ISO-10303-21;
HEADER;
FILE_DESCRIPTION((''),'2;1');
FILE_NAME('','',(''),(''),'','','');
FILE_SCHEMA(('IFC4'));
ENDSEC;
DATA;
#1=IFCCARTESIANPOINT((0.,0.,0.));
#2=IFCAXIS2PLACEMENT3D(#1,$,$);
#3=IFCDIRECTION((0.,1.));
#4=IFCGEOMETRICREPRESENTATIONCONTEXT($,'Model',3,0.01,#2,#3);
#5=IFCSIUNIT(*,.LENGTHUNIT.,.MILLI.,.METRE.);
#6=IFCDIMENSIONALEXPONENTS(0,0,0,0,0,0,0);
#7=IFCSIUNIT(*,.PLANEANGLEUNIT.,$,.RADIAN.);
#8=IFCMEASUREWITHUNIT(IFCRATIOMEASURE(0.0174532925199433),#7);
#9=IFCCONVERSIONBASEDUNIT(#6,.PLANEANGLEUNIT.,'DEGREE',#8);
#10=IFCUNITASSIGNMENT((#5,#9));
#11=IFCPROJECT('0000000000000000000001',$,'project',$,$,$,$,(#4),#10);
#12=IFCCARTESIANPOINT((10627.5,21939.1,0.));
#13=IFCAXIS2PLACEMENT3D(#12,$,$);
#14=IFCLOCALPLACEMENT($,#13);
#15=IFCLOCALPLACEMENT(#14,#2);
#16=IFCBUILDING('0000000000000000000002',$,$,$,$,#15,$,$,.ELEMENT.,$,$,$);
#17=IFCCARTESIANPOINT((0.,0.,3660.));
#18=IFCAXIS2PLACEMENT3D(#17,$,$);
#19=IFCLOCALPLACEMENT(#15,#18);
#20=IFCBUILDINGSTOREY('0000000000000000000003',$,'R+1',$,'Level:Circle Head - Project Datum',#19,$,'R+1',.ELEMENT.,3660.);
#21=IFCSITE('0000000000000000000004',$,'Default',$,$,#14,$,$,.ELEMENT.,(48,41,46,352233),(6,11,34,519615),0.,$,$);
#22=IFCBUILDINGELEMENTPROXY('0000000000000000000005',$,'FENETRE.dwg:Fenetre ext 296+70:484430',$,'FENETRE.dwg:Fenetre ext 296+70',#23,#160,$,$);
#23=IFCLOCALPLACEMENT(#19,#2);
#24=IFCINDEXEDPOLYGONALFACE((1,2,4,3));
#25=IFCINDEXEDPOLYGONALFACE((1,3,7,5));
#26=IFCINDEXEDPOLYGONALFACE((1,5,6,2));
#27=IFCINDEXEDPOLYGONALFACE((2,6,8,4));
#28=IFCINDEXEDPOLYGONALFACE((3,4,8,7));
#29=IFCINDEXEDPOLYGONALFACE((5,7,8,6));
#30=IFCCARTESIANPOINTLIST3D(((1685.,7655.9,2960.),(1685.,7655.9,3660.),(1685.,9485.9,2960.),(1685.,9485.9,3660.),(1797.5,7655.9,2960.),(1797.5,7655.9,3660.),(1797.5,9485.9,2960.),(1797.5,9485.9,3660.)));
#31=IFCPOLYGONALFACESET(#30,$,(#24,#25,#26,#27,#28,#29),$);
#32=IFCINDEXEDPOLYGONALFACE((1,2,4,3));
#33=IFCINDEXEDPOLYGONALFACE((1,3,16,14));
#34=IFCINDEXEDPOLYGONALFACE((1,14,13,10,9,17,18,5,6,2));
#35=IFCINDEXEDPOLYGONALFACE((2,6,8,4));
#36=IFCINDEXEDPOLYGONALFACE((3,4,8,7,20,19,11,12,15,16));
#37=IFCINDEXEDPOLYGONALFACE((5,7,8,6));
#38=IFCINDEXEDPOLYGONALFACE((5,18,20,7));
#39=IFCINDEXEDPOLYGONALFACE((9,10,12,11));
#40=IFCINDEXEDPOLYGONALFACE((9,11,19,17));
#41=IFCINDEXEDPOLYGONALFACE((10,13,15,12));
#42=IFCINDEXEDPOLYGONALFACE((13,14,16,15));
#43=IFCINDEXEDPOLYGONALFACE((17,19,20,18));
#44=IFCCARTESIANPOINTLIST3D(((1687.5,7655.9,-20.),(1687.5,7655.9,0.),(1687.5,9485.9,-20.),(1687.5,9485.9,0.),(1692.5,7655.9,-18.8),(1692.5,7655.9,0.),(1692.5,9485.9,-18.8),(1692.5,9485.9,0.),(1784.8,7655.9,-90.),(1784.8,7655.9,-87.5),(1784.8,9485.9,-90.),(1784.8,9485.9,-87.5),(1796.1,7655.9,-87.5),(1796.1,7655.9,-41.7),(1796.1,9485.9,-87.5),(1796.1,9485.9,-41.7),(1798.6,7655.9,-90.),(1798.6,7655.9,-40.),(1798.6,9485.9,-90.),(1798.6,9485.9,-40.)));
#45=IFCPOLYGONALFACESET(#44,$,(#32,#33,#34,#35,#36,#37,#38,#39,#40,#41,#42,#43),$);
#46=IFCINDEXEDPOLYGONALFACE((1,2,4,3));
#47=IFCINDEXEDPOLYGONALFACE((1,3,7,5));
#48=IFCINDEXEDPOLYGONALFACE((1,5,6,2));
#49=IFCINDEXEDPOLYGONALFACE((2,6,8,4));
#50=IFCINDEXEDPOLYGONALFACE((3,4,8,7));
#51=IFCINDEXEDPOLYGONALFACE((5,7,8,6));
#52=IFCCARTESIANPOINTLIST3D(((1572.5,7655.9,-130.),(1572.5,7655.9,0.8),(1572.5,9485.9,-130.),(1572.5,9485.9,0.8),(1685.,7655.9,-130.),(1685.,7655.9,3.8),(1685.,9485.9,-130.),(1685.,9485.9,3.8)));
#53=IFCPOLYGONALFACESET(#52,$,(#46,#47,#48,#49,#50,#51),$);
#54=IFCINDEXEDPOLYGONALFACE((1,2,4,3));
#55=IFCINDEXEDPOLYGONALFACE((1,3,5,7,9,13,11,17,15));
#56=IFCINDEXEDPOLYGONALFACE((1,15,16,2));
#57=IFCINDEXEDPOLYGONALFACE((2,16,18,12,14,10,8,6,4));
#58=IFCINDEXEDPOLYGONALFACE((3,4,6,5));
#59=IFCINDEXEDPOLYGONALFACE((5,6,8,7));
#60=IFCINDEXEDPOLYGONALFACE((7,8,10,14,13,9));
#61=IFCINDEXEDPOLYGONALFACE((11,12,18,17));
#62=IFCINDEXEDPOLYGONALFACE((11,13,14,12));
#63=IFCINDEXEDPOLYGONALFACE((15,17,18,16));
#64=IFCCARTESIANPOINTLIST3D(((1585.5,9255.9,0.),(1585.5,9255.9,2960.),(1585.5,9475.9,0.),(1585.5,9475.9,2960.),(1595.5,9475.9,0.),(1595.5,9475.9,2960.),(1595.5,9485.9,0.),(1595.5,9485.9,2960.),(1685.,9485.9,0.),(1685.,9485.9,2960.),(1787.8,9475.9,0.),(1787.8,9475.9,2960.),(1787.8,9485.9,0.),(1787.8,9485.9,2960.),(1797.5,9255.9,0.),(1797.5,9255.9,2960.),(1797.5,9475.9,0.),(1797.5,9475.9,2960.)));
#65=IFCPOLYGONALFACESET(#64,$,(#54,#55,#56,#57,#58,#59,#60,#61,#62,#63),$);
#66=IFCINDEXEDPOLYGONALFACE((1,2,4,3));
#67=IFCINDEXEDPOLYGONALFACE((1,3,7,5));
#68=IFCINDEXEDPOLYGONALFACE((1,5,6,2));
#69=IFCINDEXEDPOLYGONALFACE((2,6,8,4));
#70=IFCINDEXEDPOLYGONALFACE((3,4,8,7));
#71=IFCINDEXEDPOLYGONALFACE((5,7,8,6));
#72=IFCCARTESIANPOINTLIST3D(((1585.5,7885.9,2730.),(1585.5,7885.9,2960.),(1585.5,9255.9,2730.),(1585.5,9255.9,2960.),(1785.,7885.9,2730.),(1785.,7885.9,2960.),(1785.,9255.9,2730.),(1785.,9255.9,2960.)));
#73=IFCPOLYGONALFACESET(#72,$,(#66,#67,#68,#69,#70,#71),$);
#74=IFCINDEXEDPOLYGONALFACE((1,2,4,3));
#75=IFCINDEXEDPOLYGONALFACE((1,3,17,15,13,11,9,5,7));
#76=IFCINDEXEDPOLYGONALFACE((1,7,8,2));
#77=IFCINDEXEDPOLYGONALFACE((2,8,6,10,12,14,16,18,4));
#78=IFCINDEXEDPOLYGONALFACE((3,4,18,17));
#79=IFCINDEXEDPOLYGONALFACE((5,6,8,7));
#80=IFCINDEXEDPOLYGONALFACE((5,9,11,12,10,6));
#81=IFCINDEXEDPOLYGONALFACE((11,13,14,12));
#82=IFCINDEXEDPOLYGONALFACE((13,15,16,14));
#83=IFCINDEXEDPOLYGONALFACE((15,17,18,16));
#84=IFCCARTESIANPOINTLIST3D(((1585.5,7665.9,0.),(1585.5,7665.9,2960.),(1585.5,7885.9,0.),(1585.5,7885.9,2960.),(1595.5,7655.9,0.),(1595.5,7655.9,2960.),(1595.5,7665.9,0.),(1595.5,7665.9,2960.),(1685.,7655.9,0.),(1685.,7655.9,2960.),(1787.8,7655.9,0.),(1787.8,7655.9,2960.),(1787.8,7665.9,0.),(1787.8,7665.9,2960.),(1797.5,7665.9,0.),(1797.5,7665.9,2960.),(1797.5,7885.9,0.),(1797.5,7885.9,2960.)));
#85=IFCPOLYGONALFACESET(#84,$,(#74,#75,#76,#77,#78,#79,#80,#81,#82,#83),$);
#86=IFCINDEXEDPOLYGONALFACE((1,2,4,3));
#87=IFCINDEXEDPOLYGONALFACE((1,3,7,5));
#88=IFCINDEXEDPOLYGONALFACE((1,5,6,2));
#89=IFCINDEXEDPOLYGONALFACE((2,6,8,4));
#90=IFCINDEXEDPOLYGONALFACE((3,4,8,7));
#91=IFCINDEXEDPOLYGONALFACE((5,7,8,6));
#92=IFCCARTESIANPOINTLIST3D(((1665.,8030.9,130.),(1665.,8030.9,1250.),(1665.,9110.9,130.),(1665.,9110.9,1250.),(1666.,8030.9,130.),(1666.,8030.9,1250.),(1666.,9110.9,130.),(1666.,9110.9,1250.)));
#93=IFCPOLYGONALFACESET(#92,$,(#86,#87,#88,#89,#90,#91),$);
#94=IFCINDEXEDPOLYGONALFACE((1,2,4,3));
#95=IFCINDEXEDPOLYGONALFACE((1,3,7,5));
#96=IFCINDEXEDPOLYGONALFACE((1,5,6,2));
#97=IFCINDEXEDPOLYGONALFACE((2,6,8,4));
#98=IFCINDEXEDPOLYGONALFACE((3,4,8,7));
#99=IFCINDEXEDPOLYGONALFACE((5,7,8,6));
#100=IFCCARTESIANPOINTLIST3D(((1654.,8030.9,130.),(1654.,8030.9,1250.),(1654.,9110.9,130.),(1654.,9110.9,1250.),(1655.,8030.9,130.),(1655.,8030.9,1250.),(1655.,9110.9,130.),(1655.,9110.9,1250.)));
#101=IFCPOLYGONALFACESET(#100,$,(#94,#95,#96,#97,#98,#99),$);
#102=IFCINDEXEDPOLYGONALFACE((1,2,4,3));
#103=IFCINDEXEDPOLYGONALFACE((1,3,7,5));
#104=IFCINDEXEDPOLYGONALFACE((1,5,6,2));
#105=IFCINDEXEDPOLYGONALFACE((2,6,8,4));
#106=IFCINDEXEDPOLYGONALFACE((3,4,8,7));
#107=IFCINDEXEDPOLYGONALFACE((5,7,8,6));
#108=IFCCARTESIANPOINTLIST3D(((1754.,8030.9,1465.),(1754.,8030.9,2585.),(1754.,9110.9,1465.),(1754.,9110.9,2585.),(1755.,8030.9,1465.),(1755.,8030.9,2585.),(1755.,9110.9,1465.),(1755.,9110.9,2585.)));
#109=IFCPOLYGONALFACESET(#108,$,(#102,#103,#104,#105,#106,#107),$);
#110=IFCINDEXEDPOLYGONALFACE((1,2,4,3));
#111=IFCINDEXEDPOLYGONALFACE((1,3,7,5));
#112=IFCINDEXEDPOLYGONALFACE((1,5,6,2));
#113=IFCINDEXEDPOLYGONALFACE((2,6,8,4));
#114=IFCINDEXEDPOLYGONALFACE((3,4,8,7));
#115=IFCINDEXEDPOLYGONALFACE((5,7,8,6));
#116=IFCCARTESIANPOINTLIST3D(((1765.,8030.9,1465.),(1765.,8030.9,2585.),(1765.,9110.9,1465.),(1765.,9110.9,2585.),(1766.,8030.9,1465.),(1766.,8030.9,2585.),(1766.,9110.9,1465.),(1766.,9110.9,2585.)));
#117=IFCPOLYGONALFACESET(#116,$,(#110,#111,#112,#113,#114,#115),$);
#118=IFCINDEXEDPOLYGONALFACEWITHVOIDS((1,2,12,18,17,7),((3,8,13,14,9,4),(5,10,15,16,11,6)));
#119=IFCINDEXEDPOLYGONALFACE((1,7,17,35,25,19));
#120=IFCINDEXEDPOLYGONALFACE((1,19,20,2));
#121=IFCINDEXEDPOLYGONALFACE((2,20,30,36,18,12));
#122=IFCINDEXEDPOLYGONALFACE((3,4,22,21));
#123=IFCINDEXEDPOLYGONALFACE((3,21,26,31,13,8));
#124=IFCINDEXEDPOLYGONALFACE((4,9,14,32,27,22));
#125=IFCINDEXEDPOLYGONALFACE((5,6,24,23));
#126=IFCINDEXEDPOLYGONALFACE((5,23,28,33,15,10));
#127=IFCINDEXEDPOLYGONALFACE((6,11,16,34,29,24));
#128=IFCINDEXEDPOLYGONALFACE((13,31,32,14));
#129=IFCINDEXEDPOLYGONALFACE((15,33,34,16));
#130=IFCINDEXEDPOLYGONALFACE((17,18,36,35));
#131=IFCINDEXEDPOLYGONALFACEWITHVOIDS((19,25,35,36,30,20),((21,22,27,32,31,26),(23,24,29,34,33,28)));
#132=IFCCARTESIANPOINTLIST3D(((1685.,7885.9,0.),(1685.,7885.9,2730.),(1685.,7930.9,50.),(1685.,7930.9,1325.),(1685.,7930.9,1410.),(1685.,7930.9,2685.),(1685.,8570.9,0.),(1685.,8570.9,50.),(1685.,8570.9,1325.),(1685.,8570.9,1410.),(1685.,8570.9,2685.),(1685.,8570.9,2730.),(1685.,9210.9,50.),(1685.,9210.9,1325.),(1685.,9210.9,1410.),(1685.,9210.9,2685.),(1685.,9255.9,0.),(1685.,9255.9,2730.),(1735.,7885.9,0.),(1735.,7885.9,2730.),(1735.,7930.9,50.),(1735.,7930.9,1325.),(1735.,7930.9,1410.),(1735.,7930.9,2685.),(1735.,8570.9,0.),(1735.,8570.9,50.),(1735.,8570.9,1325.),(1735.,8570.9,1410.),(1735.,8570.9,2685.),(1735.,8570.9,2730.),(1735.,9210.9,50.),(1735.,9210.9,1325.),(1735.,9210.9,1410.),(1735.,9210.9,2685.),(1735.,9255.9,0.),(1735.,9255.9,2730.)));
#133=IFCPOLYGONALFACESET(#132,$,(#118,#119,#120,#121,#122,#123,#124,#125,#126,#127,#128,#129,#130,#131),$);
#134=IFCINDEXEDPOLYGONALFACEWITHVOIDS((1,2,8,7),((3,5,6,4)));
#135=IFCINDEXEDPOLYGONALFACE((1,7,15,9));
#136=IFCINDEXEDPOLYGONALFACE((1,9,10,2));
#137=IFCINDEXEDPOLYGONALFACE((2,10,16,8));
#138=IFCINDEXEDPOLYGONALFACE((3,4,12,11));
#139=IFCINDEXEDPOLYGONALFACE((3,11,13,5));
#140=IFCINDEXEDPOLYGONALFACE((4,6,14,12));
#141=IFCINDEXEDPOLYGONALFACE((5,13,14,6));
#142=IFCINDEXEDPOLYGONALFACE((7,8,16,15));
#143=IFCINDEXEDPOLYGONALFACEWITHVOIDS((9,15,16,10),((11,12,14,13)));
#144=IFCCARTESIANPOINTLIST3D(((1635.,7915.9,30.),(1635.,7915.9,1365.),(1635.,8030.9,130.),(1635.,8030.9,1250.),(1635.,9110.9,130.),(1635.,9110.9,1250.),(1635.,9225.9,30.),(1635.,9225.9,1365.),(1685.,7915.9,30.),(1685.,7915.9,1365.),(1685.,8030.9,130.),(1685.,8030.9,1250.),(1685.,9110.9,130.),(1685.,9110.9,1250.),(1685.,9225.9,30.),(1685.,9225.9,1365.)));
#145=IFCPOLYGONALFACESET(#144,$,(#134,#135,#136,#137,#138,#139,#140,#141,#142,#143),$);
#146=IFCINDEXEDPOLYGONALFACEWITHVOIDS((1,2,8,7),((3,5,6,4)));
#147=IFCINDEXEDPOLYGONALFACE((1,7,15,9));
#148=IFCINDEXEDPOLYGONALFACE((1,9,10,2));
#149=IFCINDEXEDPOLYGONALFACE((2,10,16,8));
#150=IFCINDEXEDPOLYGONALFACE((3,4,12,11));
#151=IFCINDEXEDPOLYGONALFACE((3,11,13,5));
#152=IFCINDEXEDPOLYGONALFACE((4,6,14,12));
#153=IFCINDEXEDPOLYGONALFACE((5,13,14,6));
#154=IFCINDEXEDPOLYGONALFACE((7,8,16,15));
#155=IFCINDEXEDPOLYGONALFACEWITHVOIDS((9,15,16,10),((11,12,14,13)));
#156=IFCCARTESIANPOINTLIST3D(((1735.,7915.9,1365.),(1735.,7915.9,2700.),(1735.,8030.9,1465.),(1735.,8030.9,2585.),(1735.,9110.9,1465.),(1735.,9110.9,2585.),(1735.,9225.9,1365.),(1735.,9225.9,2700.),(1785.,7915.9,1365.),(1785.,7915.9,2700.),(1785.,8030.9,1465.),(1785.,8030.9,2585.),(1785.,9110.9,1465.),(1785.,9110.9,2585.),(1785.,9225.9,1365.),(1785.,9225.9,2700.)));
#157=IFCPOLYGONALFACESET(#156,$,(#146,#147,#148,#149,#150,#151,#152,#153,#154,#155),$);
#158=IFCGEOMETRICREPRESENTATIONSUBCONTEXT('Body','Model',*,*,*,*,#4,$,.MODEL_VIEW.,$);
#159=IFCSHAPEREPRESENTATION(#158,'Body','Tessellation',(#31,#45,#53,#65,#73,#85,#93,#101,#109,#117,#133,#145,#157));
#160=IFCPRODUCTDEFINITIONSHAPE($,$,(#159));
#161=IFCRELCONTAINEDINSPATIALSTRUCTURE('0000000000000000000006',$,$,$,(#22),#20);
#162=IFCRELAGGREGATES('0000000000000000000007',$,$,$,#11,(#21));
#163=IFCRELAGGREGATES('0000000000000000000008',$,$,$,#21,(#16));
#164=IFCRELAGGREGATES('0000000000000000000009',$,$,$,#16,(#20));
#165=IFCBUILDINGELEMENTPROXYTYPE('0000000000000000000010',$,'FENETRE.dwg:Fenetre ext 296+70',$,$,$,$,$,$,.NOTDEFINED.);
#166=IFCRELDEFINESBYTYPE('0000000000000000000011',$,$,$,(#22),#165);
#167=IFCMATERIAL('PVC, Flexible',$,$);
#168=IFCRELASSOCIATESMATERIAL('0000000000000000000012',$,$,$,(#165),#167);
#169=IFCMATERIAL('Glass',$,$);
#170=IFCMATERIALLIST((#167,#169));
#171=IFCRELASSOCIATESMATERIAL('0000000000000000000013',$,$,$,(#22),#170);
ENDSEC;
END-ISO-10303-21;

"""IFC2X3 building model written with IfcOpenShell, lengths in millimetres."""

from ifc_helpers import new_model, entity, si_unit, converted_unit, direction, frame, frame_2d, origin, origin_2d_with_axis, place, context, subcontext, project, spatial, polyline, rectangle, outline, extrude, source, transform, mapped, material, material_list, type_object, type_shapes, element, save


model = new_model("IFC2X3")

# Units and contexts
model_context = context("Model", 3, precision=0.01, world=origin(), true_north=direction((0.0, 1.0)))
body_context = subcontext(model_context, "Body", "Model", "MODEL_VIEW")
ifc_project = project(units=[si_unit("LENGTHUNIT", "METRE", prefix="MILLI"), converted_unit("PLANEANGLEUNIT", "DEGREE", entity("IfcRatioMeasure", 0.0174532925199433), si_unit("PLANEANGLEUNIT", "RADIAN"), dimensions=[0, 0, 0, 0, 0, 0, 0])], contexts=[model_context])

# Site, building, storey
site_placement = place(None, frame((10627.5, 21939.1, 0.0)))
site = spatial("IfcSite", under=ifc_project, at=site_placement, Name="Default", CompositionType="ELEMENT", RefLatitude=(48, 41, 46, 352233), RefLongitude=(6, 11, 34, 519615), RefElevation=0.0)
building_placement = place(site_placement, origin())
building = spatial("IfcBuilding", under=site, at=building_placement, CompositionType="ELEMENT")
storey_placement = place(building_placement, frame((0.0, 0.0, 3660.0)))
storey = spatial("IfcBuildingStorey", under=building, at=storey_placement, Name="R+1", ObjectType="Level:Circle Head - Project Datum", LongName="R+1", CompositionType="ELEMENT", Elevation=3660.0)

# Building element proxy
ifc_material_1 = material(Name="PVC, Flexible")
ifc_material_2 = material(Name="Glass")
building_element_proxy_type_1 = type_object("IfcBuildingElementProxyType", Name="FENETRE.dwg:Fenetre ext 296+70", PredefinedType="NOTDEFINED", material=ifc_material_1)
shared_shape_1 = source(origin(), body_context, "Body", "SweptSolid", [
    extrude(rectangle(XDim=112.5, YDim=1830.0, at=origin_2d_with_axis()), frame((-10.4, -56.3, 2960.0), z_axis=(0.0, 0.0, 1.0), x_axis=(0.0, 1.0, 0.0)), (0.0, 0.0, 1.0), 700.0),
    extrude(outline(polyline([(27.5, -64.4), (47.5, -64.4), (47.5, -59.4), (28.8, -59.4), (7.5, 46.7), (-42.5, 46.7), (-42.5, 32.9), (-40.0, 32.9), (-40.0, 44.2), (5.8, 44.2), (27.5, -64.4)])), frame((-925.4, -66.9, -47.5), z_axis=(1.0, 0.0, 0.0), x_axis=(0.0, 0.0, 1.0)), (0.0, 0.0, 1.0), 1830.0),
    extrude(outline(polyline([(-54.5, -66.1), (58.0, -66.1), (54.5, 67.6), (-58.0, 64.6), (-54.5, -66.1)])), frame((-925.4, 56.3, -63.8), z_axis=(1.0, 0.0, 0.0), x_axis=(0.0, -0.999645, 0.02665)), (0.0, 0.0, 1.0), 1830.0),
    extrude(outline(polyline([(-97.0, -55.6), (5.9, -55.6), (95.4, -55.6), (95.4, -45.6), (105.4, -45.6), (105.4, 174.4), (-106.6, 174.4), (-106.6, -45.6), (-97.0, -45.6), (-97.0, -55.6)])), frame((849.0, -5.9, 0.0), z_axis=(0.0, 0.0, 1.0), x_axis=(0.0, 1.0, 0.0)), (0.0, 0.0, 1.0), 2960.0),
    extrude(rectangle(XDim=1370.0, YDim=199.5, at=origin_2d_with_axis()), frame((-10.4, -0.3, 2730.0), z_axis=(0.0, 0.0, 1.0), x_axis=(-1.0, 0.0, 0.0)), (0.0, 0.0, 1.0), 230.0),
    extrude(outline(polyline([(-55.6, 97.0), (-55.6, -5.9), (-55.6, -95.4), (-45.6, -95.4), (-45.6, -105.4), (174.4, -105.4), (174.4, 106.6), (-45.6, 106.6), (-45.6, 97.0), (-55.6, 97.0)])), frame((-869.9, -5.9, 0.0), z_axis=(0.0, 0.0, -1.0), x_axis=(1.0, 0.0, 0.0)), (0.0, 0.0, -1.0), 2960.0),
    extrude(rectangle(XDim=1080.0, YDim=1.0, at=origin_2d_with_axis()), frame((-10.4, 19.5, 130.0), z_axis=(0.0, 0.0, 1.0), x_axis=(-1.0, 0.0, 0.0)), (0.0, 0.0, 1.0), 1120.0),
    extrude(rectangle(XDim=1080.0, YDim=1.0, at=origin_2d_with_axis()), frame((-10.4, 30.5, 130.0), z_axis=(0.0, 0.0, 1.0), x_axis=(-1.0, 0.0, 0.0)), (0.0, 0.0, 1.0), 1120.0),
    extrude(rectangle(XDim=1080.0, YDim=1.0, at=frame_2d((0.0, 0.0), x_axis=(1.0, 0.0))), frame((-10.4, -69.5, 1465.0), z_axis=(0.0, 0.0, 1.0), x_axis=(-1.0, 0.0, 0.0)), (0.0, 0.0, 1.0), 1120.0),
    extrude(rectangle(XDim=1080.0, YDim=1.0, at=frame_2d((0.0, 0.0), x_axis=(1.0, 0.0))), frame((-10.4, -80.5, 1465.0), z_axis=(0.0, 0.0, 1.0), x_axis=(-1.0, 0.0, 0.0)), (0.0, 0.0, 1.0), 1120.0),
    extrude(outline(polyline([(-685.0, -1365.0), (0.0, -1365.0), (685.0, -1365.0), (685.0, 1365.0), (0.0, 1365.0), (-685.0, 1365.0), (-685.0, -1365.0)]), holes=[polyline([(-640.0, -1320.0), (-640.0, -45.0), (0.0, -45.0), (640.0, -45.0), (640.0, -1320.0), (0.0, -1320.0), (-640.0, -1320.0)]), polyline([(-640.0, 40.0), (-640.0, 1315.0), (0.0, 1315.0), (640.0, 1315.0), (640.0, 40.0), (0.0, 40.0), (-640.0, 40.0)])]), frame((-10.4, -50.0, 1365.0), z_axis=(0.0, 1.0, 0.0), x_axis=(1.0, 0.0, 0.0)), (0.0, 0.0, 1.0), 50.0),
    extrude(outline(polyline([(-655.0, -667.5), (655.0, -667.5), (655.0, 667.5), (-655.0, 667.5), (-655.0, -667.5)]), holes=[polyline([(-540.0, 552.5), (540.0, 552.5), (540.0, -567.5), (-540.0, -567.5), (-540.0, 552.5)])]), frame((-10.4, 0.0, 697.5), z_axis=(0.0, 1.0, 0.0), x_axis=(-1.0, 0.0, 0.0)), (0.0, 0.0, 1.0), 50.0),
    extrude(outline(polyline([(-655.0, -667.5), (655.0, -667.5), (655.0, 667.5), (-655.0, 667.5), (-655.0, -667.5)]), holes=[polyline([(-540.0, 552.5), (540.0, 552.5), (540.0, -567.5), (-540.0, -567.5), (-540.0, 552.5)])]), frame((-10.4, -100.0, 2032.5), z_axis=(0.0, 1.0, 0.0), x_axis=(-1.0, 0.0, 0.0)), (0.0, 0.0, 1.0), 50.0),
])
type_shapes(building_element_proxy_type_1, [shared_shape_1])
ifc_material_list_1 = material_list([ifc_material_1, ifc_material_2])
proxy_1_placement = place(storey_placement, frame((1685.0, 8581.3, 0.0), z_axis=(0.0, 0.0, 1.0), x_axis=(0.0, 1.0, 0.0)))
element("IfcBuildingElementProxy", 1, at=proxy_1_placement, inside=storey, type_object=building_element_proxy_type_1, material=ifc_material_list_1, Name="FENETRE.dwg:Fenetre ext 296+70:484430", ObjectType="FENETRE.dwg:Fenetre ext 296+70", context=body_context, shape_type="MappedRepresentation", body=[
    mapped(shared_shape_1, transform((0.0, 0.0, 0.0), scale=1.0)),
])

save(model, "model.ifc")
